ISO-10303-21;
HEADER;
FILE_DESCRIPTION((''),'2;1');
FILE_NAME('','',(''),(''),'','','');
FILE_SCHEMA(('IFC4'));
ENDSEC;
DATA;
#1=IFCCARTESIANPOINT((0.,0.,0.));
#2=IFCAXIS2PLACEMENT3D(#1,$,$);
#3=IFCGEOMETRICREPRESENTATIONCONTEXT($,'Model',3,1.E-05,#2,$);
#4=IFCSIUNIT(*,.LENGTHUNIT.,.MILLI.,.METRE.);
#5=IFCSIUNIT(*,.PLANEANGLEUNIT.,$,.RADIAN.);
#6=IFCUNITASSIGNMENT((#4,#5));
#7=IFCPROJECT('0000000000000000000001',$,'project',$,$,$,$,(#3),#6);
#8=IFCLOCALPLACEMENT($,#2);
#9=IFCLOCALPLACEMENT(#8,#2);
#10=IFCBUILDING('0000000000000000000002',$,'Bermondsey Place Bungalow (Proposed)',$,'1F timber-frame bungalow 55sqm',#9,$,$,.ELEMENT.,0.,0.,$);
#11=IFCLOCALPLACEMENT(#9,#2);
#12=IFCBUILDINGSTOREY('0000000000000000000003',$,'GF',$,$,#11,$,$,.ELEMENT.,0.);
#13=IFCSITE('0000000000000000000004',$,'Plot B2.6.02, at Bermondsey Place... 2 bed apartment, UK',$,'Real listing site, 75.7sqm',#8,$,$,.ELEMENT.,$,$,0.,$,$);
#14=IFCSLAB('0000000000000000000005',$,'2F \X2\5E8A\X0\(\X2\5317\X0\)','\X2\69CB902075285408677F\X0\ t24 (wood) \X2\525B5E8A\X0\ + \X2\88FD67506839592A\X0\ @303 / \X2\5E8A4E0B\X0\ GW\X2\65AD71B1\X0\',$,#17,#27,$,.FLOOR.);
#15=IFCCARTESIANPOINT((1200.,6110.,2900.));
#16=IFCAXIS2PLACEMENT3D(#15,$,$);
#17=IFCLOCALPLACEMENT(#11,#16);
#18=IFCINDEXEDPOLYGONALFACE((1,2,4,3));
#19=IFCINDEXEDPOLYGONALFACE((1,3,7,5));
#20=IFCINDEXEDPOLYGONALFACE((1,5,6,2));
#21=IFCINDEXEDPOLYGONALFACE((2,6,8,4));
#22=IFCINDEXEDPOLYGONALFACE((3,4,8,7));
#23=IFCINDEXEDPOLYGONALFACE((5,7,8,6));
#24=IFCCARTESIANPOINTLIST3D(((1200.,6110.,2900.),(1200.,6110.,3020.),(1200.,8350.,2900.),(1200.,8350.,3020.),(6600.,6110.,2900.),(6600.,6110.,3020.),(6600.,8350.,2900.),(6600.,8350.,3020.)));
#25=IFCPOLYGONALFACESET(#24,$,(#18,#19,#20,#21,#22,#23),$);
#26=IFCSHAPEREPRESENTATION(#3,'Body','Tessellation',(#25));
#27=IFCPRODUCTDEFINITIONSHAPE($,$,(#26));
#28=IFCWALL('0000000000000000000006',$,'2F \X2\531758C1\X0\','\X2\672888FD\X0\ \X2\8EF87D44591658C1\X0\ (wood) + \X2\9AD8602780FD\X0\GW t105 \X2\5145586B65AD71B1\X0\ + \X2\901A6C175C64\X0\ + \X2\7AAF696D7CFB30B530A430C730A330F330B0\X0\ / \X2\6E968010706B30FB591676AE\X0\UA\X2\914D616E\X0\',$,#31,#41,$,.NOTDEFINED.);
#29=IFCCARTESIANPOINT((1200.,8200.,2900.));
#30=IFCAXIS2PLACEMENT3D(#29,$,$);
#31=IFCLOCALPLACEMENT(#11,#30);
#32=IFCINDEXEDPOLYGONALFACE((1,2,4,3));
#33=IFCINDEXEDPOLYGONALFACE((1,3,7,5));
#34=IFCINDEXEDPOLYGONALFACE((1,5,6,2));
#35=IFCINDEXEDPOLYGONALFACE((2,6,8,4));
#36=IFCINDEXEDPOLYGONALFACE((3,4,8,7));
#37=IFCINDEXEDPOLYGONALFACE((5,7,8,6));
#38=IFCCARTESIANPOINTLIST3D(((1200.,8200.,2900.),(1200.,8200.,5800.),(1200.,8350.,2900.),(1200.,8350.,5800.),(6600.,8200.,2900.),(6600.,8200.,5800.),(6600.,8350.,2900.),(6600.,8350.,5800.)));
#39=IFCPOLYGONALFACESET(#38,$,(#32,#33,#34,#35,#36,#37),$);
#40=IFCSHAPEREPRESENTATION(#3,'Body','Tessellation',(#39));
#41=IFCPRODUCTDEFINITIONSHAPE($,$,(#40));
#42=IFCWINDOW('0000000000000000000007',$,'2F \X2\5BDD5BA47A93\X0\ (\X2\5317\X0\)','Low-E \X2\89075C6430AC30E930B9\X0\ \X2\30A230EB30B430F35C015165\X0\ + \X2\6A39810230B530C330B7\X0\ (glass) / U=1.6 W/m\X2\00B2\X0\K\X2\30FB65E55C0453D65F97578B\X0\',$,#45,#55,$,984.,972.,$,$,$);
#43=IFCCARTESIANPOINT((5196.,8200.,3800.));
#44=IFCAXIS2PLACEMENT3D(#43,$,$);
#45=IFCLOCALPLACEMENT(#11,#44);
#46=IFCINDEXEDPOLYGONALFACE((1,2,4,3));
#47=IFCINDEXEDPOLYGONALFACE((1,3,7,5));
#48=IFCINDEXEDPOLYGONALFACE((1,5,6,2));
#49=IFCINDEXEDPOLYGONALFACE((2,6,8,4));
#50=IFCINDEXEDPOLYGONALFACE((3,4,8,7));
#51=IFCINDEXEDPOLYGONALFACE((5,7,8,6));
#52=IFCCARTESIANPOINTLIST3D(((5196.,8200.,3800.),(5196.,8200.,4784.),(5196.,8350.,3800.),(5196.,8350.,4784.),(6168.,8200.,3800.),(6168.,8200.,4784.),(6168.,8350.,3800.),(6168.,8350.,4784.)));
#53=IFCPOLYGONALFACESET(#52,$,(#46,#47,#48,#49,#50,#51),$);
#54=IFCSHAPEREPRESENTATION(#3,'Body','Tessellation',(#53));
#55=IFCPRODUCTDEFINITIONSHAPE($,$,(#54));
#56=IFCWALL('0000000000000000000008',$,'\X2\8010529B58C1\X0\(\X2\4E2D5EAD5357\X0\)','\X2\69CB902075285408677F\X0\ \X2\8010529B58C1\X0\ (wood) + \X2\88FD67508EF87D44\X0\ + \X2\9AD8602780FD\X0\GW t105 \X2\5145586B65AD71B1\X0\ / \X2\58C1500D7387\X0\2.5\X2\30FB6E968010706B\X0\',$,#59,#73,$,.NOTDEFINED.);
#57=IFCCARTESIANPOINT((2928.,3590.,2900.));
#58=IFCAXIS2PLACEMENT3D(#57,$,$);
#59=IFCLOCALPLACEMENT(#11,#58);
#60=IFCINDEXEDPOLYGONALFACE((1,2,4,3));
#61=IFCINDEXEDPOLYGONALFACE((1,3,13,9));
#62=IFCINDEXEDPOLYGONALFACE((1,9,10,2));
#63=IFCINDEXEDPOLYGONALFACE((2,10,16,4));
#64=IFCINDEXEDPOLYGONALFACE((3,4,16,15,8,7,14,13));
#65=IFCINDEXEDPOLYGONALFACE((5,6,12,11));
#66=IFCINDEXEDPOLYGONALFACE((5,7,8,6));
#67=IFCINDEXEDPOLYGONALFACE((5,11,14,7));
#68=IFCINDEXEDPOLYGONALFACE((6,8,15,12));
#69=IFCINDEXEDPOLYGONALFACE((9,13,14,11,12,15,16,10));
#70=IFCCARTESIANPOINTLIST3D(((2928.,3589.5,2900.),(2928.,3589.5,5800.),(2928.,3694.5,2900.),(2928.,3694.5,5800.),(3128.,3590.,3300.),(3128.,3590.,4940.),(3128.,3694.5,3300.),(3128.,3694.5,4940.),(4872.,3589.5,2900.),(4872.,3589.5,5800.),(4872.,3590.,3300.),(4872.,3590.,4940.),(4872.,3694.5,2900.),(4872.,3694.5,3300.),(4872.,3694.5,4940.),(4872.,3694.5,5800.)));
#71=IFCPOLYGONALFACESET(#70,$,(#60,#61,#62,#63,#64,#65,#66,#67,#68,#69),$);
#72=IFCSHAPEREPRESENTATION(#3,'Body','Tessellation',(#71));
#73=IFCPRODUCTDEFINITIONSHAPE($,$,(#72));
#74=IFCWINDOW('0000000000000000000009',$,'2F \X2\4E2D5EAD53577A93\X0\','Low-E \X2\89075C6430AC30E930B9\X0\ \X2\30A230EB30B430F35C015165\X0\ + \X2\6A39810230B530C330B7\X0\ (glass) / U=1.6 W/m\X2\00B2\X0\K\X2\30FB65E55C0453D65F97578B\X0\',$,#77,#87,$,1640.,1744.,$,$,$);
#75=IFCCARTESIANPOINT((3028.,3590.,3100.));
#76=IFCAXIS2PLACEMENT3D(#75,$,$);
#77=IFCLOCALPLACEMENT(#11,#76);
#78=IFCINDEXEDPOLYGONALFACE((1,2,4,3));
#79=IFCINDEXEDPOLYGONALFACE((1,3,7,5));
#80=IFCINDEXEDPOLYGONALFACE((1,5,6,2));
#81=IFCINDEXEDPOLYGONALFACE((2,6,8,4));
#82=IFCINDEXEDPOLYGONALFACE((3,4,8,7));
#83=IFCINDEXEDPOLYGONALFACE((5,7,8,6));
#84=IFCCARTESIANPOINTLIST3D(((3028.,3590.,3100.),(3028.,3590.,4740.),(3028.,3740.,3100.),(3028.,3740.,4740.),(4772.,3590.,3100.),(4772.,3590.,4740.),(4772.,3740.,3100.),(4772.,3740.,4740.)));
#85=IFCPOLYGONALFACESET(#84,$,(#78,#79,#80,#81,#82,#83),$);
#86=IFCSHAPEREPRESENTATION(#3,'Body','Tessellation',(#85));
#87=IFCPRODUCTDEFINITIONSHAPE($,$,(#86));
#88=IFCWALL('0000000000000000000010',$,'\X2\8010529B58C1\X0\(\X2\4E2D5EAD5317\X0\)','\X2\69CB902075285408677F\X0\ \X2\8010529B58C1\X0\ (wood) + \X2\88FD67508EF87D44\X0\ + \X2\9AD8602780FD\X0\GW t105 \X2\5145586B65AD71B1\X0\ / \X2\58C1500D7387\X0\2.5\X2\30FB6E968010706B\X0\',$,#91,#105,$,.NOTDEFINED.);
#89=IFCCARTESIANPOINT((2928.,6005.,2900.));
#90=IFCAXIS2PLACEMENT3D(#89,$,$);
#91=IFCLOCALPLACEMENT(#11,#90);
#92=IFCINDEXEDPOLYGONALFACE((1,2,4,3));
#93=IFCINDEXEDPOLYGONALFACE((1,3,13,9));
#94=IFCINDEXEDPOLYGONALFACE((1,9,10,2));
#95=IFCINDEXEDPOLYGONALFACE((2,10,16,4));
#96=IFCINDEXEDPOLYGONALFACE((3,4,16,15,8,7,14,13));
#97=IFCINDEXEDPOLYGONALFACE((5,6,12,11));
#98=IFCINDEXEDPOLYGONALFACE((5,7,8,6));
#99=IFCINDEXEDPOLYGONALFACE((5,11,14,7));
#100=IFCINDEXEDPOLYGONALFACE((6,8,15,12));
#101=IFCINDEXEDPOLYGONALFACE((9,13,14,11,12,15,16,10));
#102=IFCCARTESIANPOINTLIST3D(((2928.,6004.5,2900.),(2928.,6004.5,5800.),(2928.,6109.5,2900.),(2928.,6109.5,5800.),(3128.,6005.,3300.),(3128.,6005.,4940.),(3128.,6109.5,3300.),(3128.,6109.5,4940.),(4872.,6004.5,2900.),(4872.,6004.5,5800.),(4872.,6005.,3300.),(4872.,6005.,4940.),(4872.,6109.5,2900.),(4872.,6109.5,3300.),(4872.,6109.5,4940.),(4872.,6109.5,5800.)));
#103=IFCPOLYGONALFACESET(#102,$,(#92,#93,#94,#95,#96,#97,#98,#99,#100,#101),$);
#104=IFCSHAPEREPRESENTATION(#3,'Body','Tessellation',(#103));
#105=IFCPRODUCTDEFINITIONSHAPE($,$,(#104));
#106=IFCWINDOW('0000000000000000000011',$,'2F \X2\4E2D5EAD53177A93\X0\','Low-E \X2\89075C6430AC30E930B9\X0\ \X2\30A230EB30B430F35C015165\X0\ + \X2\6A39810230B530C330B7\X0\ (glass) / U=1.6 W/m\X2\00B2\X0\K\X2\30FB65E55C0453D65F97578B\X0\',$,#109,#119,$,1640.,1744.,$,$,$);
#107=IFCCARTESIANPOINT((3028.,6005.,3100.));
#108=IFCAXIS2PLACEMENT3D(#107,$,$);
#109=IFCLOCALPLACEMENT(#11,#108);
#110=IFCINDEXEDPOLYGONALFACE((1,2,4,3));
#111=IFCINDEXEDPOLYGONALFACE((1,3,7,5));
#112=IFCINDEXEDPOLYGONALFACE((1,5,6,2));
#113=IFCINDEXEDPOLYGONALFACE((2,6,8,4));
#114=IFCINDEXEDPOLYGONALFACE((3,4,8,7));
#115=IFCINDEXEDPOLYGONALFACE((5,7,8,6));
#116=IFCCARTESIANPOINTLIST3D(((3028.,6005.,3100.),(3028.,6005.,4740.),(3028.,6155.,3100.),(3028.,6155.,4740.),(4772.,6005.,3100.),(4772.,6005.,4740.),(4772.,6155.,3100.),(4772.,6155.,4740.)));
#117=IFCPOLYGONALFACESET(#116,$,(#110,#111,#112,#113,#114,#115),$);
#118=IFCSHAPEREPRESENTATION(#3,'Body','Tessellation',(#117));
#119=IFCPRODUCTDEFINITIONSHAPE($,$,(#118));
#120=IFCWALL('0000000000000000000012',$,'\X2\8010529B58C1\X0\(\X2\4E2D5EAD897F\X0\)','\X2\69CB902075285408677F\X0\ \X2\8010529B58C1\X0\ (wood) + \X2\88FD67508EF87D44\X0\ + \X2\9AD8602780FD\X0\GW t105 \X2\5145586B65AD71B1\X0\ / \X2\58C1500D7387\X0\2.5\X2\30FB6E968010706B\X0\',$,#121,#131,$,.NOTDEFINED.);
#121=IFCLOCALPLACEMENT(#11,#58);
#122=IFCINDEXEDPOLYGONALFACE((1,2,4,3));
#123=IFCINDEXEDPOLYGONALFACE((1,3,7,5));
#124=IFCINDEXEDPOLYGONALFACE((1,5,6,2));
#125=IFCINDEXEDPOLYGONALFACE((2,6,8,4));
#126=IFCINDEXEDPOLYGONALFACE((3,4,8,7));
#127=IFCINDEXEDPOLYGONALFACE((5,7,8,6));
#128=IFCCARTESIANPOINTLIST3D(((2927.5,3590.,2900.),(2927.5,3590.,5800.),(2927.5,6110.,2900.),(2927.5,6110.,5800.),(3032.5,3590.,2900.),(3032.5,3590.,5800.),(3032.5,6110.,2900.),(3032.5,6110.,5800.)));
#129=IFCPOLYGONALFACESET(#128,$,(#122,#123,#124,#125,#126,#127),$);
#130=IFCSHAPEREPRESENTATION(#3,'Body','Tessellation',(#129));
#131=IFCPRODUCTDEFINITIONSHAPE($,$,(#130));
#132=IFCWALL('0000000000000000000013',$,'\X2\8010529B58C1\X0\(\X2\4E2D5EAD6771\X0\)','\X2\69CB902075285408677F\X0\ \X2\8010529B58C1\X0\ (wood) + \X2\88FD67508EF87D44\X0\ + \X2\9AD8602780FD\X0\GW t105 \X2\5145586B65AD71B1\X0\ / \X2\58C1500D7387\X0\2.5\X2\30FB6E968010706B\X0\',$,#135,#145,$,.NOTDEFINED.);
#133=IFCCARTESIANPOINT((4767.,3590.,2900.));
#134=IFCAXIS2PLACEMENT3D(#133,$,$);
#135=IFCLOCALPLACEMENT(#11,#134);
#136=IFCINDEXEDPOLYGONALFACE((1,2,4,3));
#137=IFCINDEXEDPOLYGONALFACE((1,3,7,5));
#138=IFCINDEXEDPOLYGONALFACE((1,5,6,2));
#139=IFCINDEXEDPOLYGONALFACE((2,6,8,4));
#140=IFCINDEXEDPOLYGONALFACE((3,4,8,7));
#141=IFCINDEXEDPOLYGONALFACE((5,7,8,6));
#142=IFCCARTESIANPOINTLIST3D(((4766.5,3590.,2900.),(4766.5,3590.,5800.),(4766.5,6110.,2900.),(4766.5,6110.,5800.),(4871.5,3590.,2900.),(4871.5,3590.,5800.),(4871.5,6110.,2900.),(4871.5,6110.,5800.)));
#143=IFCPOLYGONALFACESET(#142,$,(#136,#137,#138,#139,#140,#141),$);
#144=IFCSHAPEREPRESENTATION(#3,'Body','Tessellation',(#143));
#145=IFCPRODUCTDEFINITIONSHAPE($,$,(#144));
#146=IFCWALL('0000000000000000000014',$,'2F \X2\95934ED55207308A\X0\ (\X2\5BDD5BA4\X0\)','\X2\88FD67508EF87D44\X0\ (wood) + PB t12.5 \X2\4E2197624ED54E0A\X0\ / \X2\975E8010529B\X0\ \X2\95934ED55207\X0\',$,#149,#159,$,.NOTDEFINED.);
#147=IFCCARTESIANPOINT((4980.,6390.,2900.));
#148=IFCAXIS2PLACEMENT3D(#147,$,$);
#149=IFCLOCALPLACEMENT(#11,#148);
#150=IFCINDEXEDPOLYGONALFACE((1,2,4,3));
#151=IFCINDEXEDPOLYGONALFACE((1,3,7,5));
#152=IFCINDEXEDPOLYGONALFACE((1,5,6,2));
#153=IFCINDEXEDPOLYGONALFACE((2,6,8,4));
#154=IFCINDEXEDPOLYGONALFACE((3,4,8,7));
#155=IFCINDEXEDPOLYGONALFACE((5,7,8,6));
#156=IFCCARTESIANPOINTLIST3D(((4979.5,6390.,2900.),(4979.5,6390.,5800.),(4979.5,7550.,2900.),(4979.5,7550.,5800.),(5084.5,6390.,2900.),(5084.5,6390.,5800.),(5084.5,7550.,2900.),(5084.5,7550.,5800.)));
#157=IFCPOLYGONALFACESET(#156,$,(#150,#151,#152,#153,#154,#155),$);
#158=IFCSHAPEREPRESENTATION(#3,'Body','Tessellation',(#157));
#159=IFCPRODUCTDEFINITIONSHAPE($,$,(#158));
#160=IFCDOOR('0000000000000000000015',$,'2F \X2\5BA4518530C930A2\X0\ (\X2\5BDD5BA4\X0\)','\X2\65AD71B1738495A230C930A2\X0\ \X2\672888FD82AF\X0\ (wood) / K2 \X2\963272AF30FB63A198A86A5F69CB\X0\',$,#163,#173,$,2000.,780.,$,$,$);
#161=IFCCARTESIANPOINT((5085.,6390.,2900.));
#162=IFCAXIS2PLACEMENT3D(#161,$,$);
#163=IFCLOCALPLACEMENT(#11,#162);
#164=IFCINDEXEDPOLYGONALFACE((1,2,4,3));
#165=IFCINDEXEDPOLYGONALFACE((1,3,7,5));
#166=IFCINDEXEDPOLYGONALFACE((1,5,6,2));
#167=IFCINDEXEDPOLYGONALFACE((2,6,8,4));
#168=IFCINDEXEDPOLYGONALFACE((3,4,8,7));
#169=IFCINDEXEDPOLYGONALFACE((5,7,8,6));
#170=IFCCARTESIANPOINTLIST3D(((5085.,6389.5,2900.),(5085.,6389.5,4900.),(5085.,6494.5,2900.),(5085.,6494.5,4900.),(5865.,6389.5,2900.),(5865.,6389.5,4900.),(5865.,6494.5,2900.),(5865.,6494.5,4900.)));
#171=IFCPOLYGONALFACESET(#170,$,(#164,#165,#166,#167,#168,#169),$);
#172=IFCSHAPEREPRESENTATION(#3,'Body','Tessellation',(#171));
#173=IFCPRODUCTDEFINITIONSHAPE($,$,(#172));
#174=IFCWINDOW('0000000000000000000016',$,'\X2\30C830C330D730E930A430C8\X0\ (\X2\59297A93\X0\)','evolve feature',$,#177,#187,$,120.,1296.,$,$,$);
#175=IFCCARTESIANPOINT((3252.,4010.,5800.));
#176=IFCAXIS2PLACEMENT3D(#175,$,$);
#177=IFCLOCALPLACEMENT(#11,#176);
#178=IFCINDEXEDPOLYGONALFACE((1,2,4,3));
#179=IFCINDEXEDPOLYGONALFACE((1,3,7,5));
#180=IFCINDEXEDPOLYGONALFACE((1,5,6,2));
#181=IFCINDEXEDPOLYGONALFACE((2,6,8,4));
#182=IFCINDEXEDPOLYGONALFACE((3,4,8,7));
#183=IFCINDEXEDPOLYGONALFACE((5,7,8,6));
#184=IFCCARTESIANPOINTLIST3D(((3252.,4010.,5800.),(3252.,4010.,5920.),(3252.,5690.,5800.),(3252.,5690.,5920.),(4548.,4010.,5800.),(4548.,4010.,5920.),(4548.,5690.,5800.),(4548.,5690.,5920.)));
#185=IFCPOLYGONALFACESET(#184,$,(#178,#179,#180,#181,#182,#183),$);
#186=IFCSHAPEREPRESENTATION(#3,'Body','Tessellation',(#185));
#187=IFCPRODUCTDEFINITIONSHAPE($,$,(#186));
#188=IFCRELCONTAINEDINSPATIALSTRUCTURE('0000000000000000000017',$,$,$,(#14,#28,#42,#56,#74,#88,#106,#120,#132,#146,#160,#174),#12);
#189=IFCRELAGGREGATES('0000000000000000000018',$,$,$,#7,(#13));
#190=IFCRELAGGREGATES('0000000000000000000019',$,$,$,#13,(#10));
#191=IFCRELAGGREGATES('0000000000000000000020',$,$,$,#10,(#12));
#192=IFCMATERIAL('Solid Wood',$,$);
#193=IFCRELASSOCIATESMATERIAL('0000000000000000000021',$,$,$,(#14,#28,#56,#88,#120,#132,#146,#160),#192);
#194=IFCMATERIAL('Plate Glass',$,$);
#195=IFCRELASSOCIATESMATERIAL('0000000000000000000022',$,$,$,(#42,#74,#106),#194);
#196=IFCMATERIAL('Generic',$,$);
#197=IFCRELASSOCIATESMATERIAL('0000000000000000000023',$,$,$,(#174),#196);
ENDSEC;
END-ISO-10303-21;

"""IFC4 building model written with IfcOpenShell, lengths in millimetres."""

from ifc_helpers import new_model, si_unit, frame, frame_2d, origin, place, context, project, spatial, rectangle, extrude, material, element, fill, save


model = new_model("IFC4")

# Units and contexts
model_context = context("Model", 3, precision=1e-05, world=origin())
ifc_project = project(units=[si_unit("LENGTHUNIT", "METRE", prefix="MILLI"), si_unit("PLANEANGLEUNIT", "RADIAN")], contexts=[model_context])

# Site, building, storey
site_placement = place(None, origin())
site = spatial("IfcSite", under=ifc_project, at=site_placement, Name="Plot B2.6.02, at Bermondsey Place... 2 bed apartment, UK", ObjectType="Real listing site, 75.7sqm", CompositionType="ELEMENT", RefElevation=0.0)
building_placement = place(site_placement, origin())
building = spatial("IfcBuilding", under=site, at=building_placement, Name="Bermondsey Place Bungalow (Proposed)", ObjectType="1F timber-frame bungalow 55sqm", CompositionType="ELEMENT", ElevationOfRefHeight=0.0, ElevationOfTerrain=0.0)
storey_placement = place(building_placement, origin())
storey = spatial("IfcBuildingStorey", under=building, at=storey_placement, Name="GF", CompositionType="ELEMENT", Elevation=0.0)

# Slab
ifc_material_1 = material(Name="Solid Wood")
slab_placement = place(storey_placement, frame((1200.0, 6110.0, 2900.0)))
element("IfcSlab", 1, at=slab_placement, inside=storey, material=ifc_material_1, Name="2F 床(北)", Description="構造用合板 t24 (wood) 剛床 + 製材根太 @303 / 床下 GW断熱", PredefinedType="FLOOR", context=model_context, shape_type="SweptSolid", body=[
    extrude(rectangle(XDim=5400.0, YDim=2240.0, at=frame_2d((2700.0, 1120.0))), frame((1200.0, 6110.0, 2900.0)), (0.0, 0.0, 1.0), 120.0),
])

# Walls, openings, windows
wall_1_placement = place(storey_placement, frame((1200.0, 8200.0, 2900.0)))
wall_1 = element("IfcWall", 2, at=wall_1_placement, inside=storey, material=ifc_material_1, Name="2F 北壁", Description="木製 軸組外壁 (wood) + 高性能GW t105 充填断熱 + 通気層 + 窯業系サイディング / 準耐火・外皮UA配慮", PredefinedType="NOTDEFINED", context=model_context, shape_type="SweptSolid", body=[
    extrude(rectangle(XDim=5400.0, YDim=150.0, at=frame_2d((2700.0, 75.0))), frame((1200.0, 8200.0, 2900.0)), (0.0, 0.0, 1.0), 2900.0),
])
opening_1_placement = place(storey_placement, frame((5196.0, 8200.0, 3800.0)))
opening_1 = element("IfcOpeningElement", 3, at=opening_1_placement, cuts=wall_1, PredefinedType="NOTDEFINED", context=model_context, shape_type="SweptSolid", body=[
    extrude(rectangle(XDim=972.0, YDim=150.0, at=frame_2d((486.0, 75.0))), frame((5196.0, 8200.0, 3800.0)), (0.0, 0.0, 1.0), 984.0),
])
ifc_material_2 = material(Name="Plate Glass")
window_1_placement = place(storey_placement, frame((5196.0, 8200.0, 3800.0)))
window_1 = element("IfcWindow", 4, at=window_1_placement, inside=storey, material=ifc_material_2, Name="2F 寝室窓 (北)", Description="Low-E 複層ガラス アルゴン封入 + 樹脂サッシ (glass) / U=1.6 W/m²K・日射取得型", OverallHeight=984.0, OverallWidth=972.0, context=model_context, shape_type="SweptSolid", body=[
    extrude(rectangle(XDim=972.0, YDim=150.0, at=frame_2d((486.0, 75.0))), frame((5196.0, 8200.0, 3800.0)), (0.0, 0.0, 1.0), 984.0),
])
fill(opening_1, window_1)
wall_2_placement = place(storey_placement, frame((2928.0, 3590.0, 2900.0)))
wall_2 = element("IfcWall", 5, at=wall_2_placement, inside=storey, material=ifc_material_1, Name="耐力壁(中庭南)", Description="構造用合板 耐力壁 (wood) + 製材軸組 + 高性能GW t105 充填断熱 / 壁倍率2.5・準耐火", PredefinedType="NOTDEFINED", context=model_context, shape_type="SweptSolid", body=[
    extrude(rectangle(XDim=1944.0, YDim=105.0, at=frame_2d((972.0, 52.0))), frame((2928.0, 3590.0, 2900.0)), (0.0, 0.0, 1.0), 2900.0),
])
opening_2_placement = place(storey_placement, frame((3028.0, 3590.0, 3100.0)))
opening_2 = element("IfcOpeningElement", 6, at=opening_2_placement, cuts=wall_2, PredefinedType="NOTDEFINED", context=model_context, shape_type="SweptSolid", body=[
    extrude(rectangle(XDim=1744.0, YDim=150.0, at=frame_2d((872.0, 75.0))), frame((3028.0, 3590.0, 3100.0)), (0.0, 0.0, 1.0), 1640.0),
])
window_2_placement = place(storey_placement, frame((3028.0, 3590.0, 3100.0)))
window_2 = element("IfcWindow", 7, at=window_2_placement, inside=storey, material=ifc_material_2, Name="2F 中庭南窓", Description="Low-E 複層ガラス アルゴン封入 + 樹脂サッシ (glass) / U=1.6 W/m²K・日射取得型", OverallHeight=1640.0, OverallWidth=1744.0, context=model_context, shape_type="SweptSolid", body=[
    extrude(rectangle(XDim=1744.0, YDim=150.0, at=frame_2d((872.0, 75.0))), frame((3028.0, 3590.0, 3100.0)), (0.0, 0.0, 1.0), 1640.0),
])
fill(opening_2, window_2)
wall_3_placement = place(storey_placement, frame((2928.0, 6005.0, 2900.0)))
wall_3 = element("IfcWall", 8, at=wall_3_placement, inside=storey, material=ifc_material_1, Name="耐力壁(中庭北)", Description="構造用合板 耐力壁 (wood) + 製材軸組 + 高性能GW t105 充填断熱 / 壁倍率2.5・準耐火", PredefinedType="NOTDEFINED", context=model_context, shape_type="SweptSolid", body=[
    extrude(rectangle(XDim=1944.0, YDim=105.0, at=frame_2d((972.0, 52.0))), frame((2928.0, 6005.0, 2900.0)), (0.0, 0.0, 1.0), 2900.0),
])
opening_3_placement = place(storey_placement, frame((3028.0, 6005.0, 3100.0)))
opening_3 = element("IfcOpeningElement", 9, at=opening_3_placement, cuts=wall_3, PredefinedType="NOTDEFINED", context=model_context, shape_type="SweptSolid", body=[
    extrude(rectangle(XDim=1744.0, YDim=150.0, at=frame_2d((872.0, 75.0))), frame((3028.0, 6005.0, 3100.0)), (0.0, 0.0, 1.0), 1640.0),
])
window_3_placement = place(storey_placement, frame((3028.0, 6005.0, 3100.0)))
window_3 = element("IfcWindow", 10, at=window_3_placement, inside=storey, material=ifc_material_2, Name="2F 中庭北窓", Description="Low-E 複層ガラス アルゴン封入 + 樹脂サッシ (glass) / U=1.6 W/m²K・日射取得型", OverallHeight=1640.0, OverallWidth=1744.0, context=model_context, shape_type="SweptSolid", body=[
    extrude(rectangle(XDim=1744.0, YDim=150.0, at=frame_2d((872.0, 75.0))), frame((3028.0, 6005.0, 3100.0)), (0.0, 0.0, 1.0), 1640.0),
])
fill(opening_3, window_3)

# Walls
wall_4_placement = place(storey_placement, frame((2928.0, 3590.0, 2900.0)))
element("IfcWall", 11, at=wall_4_placement, inside=storey, material=ifc_material_1, Name="耐力壁(中庭西)", Description="構造用合板 耐力壁 (wood) + 製材軸組 + 高性能GW t105 充填断熱 / 壁倍率2.5・準耐火", PredefinedType="NOTDEFINED", context=model_context, shape_type="SweptSolid", body=[
    extrude(rectangle(XDim=105.0, YDim=2520.0, at=frame_2d((52.0, 1260.0))), frame((2928.0, 3590.0, 2900.0)), (0.0, 0.0, 1.0), 2900.0),
])
wall_5_placement = place(storey_placement, frame((4767.0, 3590.0, 2900.0)))
element("IfcWall", 12, at=wall_5_placement, inside=storey, material=ifc_material_1, Name="耐力壁(中庭東)", Description="構造用合板 耐力壁 (wood) + 製材軸組 + 高性能GW t105 充填断熱 / 壁倍率2.5・準耐火", PredefinedType="NOTDEFINED", context=model_context, shape_type="SweptSolid", body=[
    extrude(rectangle(XDim=105.0, YDim=2520.0, at=frame_2d((52.0, 1260.0))), frame((4767.0, 3590.0, 2900.0)), (0.0, 0.0, 1.0), 2900.0),
])
wall_6_placement = place(storey_placement, frame((4980.0, 6390.0, 2900.0)))
element("IfcWall", 13, at=wall_6_placement, inside=storey, material=ifc_material_1, Name="2F 間仕切り (寝室)", Description="製材軸組 (wood) + PB t12.5 両面仕上 / 非耐力 間仕切", PredefinedType="NOTDEFINED", context=model_context, shape_type="SweptSolid", body=[
    extrude(rectangle(XDim=105.0, YDim=1160.0, at=frame_2d((52.0, 580.0))), frame((4980.0, 6390.0, 2900.0)), (0.0, 0.0, 1.0), 2900.0),
])

# Door
door_placement = place(storey_placement, frame((5085.0, 6390.0, 2900.0)))
element("IfcDoor", 14, at=door_placement, inside=storey, material=ifc_material_1, Name="2F 室内ドア (寝室)", Description="断熱玄関ドア 木製芯 (wood) / K2 防犯・採風機構", OverallHeight=2000.0, OverallWidth=780.0, context=model_context, shape_type="SweptSolid", body=[
    extrude(rectangle(XDim=780.0, YDim=105.0, at=frame_2d((390.0, 52.0))), frame((5085.0, 6390.0, 2900.0)), (0.0, 0.0, 1.0), 2000.0),
])

# Window
ifc_material_3 = material(Name="Generic")
window_4_placement = place(storey_placement, frame((3252.0, 4010.0, 5800.0)))
element("IfcWindow", 15, at=window_4_placement, inside=storey, material=ifc_material_3, Name="トップライト (天窓)", Description="evolve feature", OverallHeight=120.0, OverallWidth=1296.0, context=model_context, shape_type="SweptSolid", body=[
    extrude(rectangle(XDim=1296.0, YDim=1680.0, at=frame_2d((648.0, 840.0))), frame((3252.0, 4010.0, 5800.0)), (0.0, 0.0, 1.0), 120.0),
])

save(model, "model.ifc")
